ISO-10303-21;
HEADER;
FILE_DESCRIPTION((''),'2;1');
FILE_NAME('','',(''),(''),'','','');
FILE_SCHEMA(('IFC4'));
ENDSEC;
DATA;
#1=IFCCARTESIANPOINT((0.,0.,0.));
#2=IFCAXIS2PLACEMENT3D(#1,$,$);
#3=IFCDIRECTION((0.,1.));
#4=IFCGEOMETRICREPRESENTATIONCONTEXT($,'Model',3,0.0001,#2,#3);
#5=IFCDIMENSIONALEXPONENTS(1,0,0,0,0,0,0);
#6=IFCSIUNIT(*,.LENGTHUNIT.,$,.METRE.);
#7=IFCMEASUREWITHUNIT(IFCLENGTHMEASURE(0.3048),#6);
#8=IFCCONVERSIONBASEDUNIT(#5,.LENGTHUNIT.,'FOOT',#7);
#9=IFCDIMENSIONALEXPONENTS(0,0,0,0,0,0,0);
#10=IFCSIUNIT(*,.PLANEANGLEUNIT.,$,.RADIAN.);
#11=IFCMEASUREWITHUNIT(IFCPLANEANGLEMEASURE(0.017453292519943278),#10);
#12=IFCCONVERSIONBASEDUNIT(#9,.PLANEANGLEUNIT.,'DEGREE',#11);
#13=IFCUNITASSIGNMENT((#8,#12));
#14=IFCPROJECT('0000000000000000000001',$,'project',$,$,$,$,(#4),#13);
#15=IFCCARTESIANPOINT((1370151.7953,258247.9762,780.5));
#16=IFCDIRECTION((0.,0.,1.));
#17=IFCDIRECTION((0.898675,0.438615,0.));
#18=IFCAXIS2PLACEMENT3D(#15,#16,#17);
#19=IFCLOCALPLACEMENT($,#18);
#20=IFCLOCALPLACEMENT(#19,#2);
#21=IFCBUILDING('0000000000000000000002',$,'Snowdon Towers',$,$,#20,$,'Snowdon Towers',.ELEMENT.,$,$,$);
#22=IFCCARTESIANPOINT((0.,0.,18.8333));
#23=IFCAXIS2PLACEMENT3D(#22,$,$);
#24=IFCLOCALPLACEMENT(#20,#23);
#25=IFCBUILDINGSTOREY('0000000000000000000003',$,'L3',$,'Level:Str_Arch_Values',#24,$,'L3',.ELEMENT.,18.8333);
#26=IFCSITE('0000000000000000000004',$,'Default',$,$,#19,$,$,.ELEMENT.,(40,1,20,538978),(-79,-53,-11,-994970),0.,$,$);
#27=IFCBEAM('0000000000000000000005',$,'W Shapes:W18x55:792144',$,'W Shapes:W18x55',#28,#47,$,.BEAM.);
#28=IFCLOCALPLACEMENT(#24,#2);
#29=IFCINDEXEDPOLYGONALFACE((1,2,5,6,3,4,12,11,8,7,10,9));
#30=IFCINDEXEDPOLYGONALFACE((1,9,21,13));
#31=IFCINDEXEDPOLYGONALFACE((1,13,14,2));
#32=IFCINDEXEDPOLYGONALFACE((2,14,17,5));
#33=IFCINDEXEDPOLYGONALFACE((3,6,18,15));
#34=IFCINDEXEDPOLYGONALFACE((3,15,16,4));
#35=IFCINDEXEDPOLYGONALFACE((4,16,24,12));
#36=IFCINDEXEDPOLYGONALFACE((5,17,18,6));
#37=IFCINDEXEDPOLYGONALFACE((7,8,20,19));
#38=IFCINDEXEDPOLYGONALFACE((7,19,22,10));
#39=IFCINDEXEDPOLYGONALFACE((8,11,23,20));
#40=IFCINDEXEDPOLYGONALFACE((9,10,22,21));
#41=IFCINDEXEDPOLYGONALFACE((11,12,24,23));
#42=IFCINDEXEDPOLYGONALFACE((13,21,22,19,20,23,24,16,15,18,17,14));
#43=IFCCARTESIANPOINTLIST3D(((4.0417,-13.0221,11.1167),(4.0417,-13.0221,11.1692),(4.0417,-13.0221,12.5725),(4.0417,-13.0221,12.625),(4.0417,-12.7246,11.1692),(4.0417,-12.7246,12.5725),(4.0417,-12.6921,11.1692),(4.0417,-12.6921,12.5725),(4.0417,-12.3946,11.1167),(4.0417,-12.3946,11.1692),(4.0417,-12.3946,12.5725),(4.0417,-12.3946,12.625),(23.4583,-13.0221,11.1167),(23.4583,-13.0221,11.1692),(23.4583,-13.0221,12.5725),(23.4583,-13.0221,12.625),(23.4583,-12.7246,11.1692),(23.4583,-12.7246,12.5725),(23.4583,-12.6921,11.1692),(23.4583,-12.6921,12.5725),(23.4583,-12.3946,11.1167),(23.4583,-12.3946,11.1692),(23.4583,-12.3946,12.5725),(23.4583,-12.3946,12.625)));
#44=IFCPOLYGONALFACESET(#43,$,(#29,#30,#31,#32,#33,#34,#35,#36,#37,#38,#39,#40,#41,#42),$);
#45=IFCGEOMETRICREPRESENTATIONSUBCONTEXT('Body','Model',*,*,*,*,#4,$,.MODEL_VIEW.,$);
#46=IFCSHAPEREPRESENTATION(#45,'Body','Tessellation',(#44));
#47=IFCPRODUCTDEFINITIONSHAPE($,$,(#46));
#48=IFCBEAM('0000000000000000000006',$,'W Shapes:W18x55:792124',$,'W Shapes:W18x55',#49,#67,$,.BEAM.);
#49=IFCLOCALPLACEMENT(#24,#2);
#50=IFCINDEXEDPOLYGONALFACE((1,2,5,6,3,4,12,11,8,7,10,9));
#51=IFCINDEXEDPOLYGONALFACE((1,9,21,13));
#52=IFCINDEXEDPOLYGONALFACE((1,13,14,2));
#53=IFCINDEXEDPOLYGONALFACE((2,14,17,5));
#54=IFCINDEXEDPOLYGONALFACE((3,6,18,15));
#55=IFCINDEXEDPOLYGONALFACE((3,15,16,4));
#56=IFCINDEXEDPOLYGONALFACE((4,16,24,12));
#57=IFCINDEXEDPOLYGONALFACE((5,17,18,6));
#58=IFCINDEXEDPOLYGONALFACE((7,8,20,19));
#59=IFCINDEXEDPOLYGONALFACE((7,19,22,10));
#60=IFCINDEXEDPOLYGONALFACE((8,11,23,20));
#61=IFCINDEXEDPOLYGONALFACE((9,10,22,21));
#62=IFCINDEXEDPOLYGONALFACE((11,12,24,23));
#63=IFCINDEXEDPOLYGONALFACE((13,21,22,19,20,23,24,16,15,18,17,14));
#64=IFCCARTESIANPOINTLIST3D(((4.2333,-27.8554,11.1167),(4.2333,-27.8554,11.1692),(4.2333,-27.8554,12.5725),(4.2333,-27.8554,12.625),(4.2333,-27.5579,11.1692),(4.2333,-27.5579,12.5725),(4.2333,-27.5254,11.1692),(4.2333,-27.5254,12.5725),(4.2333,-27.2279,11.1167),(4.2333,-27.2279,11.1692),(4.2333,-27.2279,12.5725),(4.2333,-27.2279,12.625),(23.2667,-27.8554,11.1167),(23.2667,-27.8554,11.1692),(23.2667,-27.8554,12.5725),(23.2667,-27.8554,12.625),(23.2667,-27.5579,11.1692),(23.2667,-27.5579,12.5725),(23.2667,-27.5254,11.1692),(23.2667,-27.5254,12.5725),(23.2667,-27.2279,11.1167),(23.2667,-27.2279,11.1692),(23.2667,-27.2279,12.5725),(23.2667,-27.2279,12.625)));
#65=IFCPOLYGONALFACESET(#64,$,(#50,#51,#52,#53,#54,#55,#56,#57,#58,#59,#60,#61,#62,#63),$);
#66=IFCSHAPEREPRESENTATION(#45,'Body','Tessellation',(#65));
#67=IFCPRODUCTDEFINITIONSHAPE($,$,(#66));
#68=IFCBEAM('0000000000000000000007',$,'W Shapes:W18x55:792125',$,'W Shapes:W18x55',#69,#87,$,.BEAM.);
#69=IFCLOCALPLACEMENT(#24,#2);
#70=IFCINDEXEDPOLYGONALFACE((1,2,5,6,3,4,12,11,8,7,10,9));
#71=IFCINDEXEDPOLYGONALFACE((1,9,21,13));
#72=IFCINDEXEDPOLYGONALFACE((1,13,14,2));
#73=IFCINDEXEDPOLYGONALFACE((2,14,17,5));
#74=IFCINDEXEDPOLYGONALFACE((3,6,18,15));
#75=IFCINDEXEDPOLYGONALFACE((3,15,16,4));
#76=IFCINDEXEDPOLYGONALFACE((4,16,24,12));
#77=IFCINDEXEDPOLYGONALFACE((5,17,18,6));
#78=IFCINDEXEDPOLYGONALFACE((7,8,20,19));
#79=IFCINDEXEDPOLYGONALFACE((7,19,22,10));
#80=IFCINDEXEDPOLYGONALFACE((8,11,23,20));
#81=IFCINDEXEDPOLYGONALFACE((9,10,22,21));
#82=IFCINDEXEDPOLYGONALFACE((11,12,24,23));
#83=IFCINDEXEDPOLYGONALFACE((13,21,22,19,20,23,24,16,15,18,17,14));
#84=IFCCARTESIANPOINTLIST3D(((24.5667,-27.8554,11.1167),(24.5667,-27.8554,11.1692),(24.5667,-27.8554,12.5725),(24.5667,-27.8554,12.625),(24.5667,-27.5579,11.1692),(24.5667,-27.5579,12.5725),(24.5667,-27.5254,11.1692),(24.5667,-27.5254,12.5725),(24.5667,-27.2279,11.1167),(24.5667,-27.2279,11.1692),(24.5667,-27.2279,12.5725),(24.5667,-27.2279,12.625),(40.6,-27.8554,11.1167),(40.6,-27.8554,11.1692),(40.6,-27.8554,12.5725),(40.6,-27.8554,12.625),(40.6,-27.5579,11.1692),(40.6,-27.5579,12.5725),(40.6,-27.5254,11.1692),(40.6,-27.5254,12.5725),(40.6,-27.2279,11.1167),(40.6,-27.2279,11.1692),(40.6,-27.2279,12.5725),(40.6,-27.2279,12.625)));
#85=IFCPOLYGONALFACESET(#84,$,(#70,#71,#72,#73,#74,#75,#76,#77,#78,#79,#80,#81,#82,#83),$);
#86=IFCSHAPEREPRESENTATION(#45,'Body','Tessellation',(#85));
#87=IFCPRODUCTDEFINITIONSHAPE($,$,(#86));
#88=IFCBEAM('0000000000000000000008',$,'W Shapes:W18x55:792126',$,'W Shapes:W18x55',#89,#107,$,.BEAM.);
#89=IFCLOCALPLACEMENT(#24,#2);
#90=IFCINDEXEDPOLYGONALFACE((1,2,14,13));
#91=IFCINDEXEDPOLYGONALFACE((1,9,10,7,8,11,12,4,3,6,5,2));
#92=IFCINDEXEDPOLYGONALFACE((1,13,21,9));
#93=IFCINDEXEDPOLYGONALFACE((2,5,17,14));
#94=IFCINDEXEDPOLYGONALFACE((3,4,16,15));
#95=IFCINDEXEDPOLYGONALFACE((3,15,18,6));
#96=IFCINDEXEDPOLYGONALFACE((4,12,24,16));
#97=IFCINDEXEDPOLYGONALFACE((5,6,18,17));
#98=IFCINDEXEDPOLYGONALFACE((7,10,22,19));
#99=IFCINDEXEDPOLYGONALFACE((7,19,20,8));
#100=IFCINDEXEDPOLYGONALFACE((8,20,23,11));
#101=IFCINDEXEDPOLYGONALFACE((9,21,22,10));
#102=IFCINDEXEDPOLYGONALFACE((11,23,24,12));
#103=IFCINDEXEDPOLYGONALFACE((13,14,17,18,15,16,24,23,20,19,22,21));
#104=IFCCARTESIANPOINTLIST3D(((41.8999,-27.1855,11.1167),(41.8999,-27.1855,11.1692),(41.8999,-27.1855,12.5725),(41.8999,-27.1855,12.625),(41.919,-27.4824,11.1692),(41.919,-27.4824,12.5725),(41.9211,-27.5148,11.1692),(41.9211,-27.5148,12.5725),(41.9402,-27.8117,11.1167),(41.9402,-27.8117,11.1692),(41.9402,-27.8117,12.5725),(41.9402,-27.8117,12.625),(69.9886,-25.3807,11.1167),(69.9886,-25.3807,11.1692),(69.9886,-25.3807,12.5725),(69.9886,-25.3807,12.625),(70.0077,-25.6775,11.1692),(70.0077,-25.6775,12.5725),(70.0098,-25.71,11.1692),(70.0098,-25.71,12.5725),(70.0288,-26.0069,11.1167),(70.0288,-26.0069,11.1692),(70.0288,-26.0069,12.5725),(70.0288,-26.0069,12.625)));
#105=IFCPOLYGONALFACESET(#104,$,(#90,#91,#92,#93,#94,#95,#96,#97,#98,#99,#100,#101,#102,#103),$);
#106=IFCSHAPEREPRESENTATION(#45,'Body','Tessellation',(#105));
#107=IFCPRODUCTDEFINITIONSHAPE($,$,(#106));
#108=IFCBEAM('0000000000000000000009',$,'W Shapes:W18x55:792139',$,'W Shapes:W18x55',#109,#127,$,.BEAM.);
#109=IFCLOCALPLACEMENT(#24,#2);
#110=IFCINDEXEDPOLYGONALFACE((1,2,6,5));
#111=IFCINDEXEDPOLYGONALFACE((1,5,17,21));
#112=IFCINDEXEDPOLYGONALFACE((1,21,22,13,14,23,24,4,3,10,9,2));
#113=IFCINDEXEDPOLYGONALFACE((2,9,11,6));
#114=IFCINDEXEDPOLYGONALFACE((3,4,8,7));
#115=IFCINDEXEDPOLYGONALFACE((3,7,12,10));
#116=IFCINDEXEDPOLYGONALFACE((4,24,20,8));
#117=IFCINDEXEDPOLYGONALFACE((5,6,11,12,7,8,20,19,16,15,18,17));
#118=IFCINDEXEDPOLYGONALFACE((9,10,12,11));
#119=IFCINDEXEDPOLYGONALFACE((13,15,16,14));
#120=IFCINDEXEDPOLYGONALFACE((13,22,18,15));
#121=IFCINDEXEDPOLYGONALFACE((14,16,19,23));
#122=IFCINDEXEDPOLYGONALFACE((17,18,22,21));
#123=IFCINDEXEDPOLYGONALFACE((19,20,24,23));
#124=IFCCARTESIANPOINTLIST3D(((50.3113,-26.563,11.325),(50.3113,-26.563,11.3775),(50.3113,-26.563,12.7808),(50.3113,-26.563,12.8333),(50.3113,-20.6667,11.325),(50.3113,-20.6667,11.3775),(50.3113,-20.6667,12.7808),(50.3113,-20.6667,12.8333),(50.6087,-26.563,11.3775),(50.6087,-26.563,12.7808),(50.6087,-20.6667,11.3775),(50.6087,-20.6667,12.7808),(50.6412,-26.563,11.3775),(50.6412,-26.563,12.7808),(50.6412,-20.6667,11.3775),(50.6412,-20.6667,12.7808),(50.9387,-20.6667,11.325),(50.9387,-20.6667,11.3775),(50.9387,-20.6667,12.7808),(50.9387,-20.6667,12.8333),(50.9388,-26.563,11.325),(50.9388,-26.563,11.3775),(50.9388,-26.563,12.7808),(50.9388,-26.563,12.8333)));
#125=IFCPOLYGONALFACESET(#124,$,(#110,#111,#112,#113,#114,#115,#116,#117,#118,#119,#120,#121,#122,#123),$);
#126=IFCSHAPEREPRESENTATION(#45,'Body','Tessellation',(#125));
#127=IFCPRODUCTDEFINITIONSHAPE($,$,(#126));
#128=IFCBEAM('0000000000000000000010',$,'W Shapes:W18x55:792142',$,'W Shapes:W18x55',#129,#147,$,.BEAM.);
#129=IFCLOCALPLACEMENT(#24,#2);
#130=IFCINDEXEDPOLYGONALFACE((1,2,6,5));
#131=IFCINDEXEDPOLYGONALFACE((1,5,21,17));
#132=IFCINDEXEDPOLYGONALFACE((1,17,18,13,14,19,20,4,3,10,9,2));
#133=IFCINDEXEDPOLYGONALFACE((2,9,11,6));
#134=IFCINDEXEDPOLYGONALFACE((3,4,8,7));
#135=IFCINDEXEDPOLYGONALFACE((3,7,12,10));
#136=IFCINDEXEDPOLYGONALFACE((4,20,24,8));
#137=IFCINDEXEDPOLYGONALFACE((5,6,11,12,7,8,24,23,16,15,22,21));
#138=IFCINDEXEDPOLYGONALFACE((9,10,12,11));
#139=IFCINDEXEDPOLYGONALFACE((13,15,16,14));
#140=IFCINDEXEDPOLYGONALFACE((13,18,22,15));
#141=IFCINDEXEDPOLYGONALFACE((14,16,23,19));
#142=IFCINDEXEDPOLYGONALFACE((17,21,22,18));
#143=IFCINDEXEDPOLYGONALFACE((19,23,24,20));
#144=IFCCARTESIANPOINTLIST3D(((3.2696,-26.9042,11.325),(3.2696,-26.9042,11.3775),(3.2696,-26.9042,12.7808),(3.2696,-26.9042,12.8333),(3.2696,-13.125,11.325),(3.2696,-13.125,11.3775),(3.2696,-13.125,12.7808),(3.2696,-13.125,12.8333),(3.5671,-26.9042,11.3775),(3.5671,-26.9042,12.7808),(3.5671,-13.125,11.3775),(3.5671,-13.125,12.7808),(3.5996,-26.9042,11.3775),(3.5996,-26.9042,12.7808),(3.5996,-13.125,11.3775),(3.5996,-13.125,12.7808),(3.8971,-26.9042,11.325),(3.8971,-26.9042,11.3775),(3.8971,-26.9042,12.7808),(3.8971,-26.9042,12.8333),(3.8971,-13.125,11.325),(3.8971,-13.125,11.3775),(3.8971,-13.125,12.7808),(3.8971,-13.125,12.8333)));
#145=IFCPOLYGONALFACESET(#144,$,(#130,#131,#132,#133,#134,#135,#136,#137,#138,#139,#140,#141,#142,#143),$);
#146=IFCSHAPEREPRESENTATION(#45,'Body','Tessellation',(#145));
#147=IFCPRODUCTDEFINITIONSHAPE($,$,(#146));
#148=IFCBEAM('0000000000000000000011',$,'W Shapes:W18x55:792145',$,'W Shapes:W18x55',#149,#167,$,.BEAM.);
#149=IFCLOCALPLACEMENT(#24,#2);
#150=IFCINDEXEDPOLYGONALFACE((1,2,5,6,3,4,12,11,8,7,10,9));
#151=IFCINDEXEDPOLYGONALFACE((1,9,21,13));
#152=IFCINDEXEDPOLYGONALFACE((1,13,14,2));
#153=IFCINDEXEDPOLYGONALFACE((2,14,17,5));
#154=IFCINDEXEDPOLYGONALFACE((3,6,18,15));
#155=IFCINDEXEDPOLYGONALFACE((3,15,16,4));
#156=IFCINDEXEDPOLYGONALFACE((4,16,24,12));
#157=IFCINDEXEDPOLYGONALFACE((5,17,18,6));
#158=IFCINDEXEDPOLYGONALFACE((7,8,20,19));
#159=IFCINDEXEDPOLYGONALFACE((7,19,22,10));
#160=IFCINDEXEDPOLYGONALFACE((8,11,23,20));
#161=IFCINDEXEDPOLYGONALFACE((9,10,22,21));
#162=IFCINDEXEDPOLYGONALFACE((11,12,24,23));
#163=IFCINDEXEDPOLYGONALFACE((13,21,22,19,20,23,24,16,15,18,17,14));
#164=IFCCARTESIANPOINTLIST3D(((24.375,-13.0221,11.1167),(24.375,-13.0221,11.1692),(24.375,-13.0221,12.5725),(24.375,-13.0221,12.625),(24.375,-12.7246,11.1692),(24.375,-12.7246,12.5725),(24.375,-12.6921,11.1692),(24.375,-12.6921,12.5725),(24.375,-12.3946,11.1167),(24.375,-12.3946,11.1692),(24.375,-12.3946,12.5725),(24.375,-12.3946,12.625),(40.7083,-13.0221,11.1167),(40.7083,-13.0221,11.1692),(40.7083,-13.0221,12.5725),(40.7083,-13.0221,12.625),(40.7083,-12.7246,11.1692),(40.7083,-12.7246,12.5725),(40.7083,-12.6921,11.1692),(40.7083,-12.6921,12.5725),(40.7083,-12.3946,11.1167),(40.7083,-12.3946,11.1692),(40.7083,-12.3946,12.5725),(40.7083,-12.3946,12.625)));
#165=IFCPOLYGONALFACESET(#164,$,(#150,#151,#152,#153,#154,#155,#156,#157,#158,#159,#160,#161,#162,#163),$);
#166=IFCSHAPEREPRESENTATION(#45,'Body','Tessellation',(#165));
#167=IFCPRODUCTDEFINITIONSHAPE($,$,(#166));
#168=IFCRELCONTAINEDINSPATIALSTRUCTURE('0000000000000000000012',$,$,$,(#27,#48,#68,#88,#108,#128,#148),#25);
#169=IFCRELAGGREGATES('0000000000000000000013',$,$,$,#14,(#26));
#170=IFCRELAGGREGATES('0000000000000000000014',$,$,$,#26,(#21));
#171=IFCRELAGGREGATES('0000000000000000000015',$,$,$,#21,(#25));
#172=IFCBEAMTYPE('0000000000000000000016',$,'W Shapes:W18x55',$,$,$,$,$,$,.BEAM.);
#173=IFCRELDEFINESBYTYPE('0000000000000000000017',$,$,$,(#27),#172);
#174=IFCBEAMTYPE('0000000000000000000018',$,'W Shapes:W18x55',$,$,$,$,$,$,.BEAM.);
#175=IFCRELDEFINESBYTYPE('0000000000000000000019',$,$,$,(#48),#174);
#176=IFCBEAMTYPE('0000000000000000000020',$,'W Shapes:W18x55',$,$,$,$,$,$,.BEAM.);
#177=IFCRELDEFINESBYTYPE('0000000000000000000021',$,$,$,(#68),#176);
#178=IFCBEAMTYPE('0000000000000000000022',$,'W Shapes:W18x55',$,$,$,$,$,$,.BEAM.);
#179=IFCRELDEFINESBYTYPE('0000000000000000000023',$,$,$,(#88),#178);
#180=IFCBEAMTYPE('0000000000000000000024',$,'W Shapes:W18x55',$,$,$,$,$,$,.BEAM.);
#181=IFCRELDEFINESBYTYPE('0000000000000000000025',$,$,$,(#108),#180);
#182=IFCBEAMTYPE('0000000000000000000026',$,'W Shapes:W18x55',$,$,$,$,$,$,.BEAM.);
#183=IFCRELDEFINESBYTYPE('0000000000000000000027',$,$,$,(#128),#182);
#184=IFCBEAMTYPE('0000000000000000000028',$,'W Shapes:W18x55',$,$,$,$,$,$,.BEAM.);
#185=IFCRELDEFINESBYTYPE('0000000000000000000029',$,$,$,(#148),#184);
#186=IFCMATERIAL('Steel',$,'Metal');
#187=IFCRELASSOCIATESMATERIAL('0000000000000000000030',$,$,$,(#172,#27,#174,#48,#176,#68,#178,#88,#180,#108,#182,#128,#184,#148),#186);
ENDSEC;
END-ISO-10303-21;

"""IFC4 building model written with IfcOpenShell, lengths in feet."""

from ifc_helpers import new_model, entity, si_unit, converted_unit, direction, frame, origin, place, context, subcontext, project, spatial, indexed_curve, outline, extrude, source, transform, mapped, material, type_object, type_shapes, element, save


model = new_model("IFC4")

# Units and contexts
model_context = context("Model", 3, precision=0.0001, world=origin(), true_north=direction((0.0, 1.0)))
body_context = subcontext(model_context, "Body", "Model", "MODEL_VIEW")
ifc_project = project(units=[converted_unit("LENGTHUNIT", "FOOT", entity("IfcLengthMeasure", 0.3048), si_unit("LENGTHUNIT", "METRE"), dimensions=[1, 0, 0, 0, 0, 0, 0]), converted_unit("PLANEANGLEUNIT", "DEGREE", entity("IfcPlaneAngleMeasure", 0.017453292519943278), si_unit("PLANEANGLEUNIT", "RADIAN"), dimensions=[0, 0, 0, 0, 0, 0, 0])], contexts=[model_context])

# Site, building, storey
site_placement = place(None, frame((1370151.7953, 258247.9762, 780.5), z_axis=(0.0, 0.0, 1.0), x_axis=(0.898675, 0.438615, 0.0)))
site = spatial("IfcSite", under=ifc_project, at=site_placement, Name="Default", CompositionType="ELEMENT", RefLatitude=(40, 1, 20, 538978), RefLongitude=(-79, -53, -11, -994970), RefElevation=0.0)
building_placement = place(site_placement, origin())
building = spatial("IfcBuilding", under=site, at=building_placement, Name="Snowdon Towers", LongName="Snowdon Towers", CompositionType="ELEMENT")
storey_placement = place(building_placement, frame((0.0, 0.0, 18.8333)))
storey = spatial("IfcBuildingStorey", under=building, at=storey_placement, Name="L3", ObjectType="Level:Str_Arch_Values", LongName="L3", CompositionType="ELEMENT", Elevation=18.8333)

# Beams
ifc_material = material(Name="Steel", Category="Metal")
beam_type_1 = type_object("IfcBeamType", Name="W Shapes:W18x55", PredefinedType="BEAM", material=ifc_material)
shared_shape_1 = source(origin(), body_context, "Body", "SweptSolid", [
    extrude(outline(indexed_curve([(-0.3138, -0.7017), (-0.3138, -0.7542), (0.3138, -0.7542), (0.3138, -0.7017), (0.0162, -0.7017), (0.0162, 0.7017), (0.3138, 0.7017), (0.3138, 0.7542), (-0.3137, 0.7542), (-0.3137, 0.7017), (-0.0163, 0.7017), (-0.0163, -0.7017), (-0.3138, -0.7017)], self_intersect=False)), frame((-9.7917, 0.0, 0.0), z_axis=(-1.0, 0.0, 0.0), x_axis=(0.0, -1.0, 0.0)), (0.0, 0.0, -1.0), 19.4167),
])
type_shapes(beam_type_1, [shared_shape_1])
beam_1_placement = place(storey_placement, frame((13.8333, -12.7083, 11.8708)))
element("IfcBeam", 1, at=beam_1_placement, inside=storey, type_object=beam_type_1, material=ifc_material, Name="W Shapes:W18x55:792144", ObjectType="W Shapes:W18x55", PredefinedType="BEAM", context=body_context, shape_type="MappedRepresentation", body=[
    mapped(shared_shape_1, transform((0.0, 0.0, 0.0), scale=1.0)),
])
beam_type_2 = type_object("IfcBeamType", Name="W Shapes:W18x55", PredefinedType="BEAM", material=ifc_material)
shared_shape_2 = source(origin(), body_context, "Body", "SweptSolid", [
    extrude(outline(indexed_curve([(-0.3138, -0.7017), (-0.3138, -0.7542), (0.3138, -0.7542), (0.3138, -0.7017), (0.0162, -0.7017), (0.0162, 0.7017), (0.3138, 0.7017), (0.3138, 0.7542), (-0.3137, 0.7542), (-0.3137, 0.7017), (-0.0163, 0.7017), (-0.0163, -0.7017), (-0.3138, -0.7017)], self_intersect=False)), frame((-9.6, 0.0, 0.0), z_axis=(-1.0, 0.0, 0.0), x_axis=(0.0, -1.0, 0.0)), (0.0, 0.0, -1.0), 19.0333),
])
type_shapes(beam_type_2, [shared_shape_2])
beam_2_placement = place(storey_placement, frame((13.8333, -27.5417, 11.8708)))
element("IfcBeam", 2, at=beam_2_placement, inside=storey, type_object=beam_type_2, material=ifc_material, Name="W Shapes:W18x55:792124", ObjectType="W Shapes:W18x55", PredefinedType="BEAM", context=body_context, shape_type="MappedRepresentation", body=[
    mapped(shared_shape_2, transform((0.0, 0.0, 0.0), scale=1.0)),
])
beam_type_3 = type_object("IfcBeamType", Name="W Shapes:W18x55", PredefinedType="BEAM", material=ifc_material)
shared_shape_3 = source(origin(), body_context, "Body", "SweptSolid", [
    extrude(outline(indexed_curve([(-0.3138, -0.7017), (-0.3138, -0.7542), (0.3138, -0.7542), (0.3138, -0.7017), (0.0162, -0.7017), (0.0162, 0.7017), (0.3138, 0.7017), (0.3138, 0.7542), (-0.3137, 0.7542), (-0.3137, 0.7017), (-0.0163, 0.7017), (-0.0163, -0.7017), (-0.3138, -0.7017)], self_intersect=False)), frame((-8.0167, 0.0, 0.0), z_axis=(-1.0, 0.0, 0.0), x_axis=(0.0, -1.0, 0.0)), (0.0, 0.0, -1.0), 16.0333),
])
type_shapes(beam_type_3, [shared_shape_3])
beam_3_placement = place(storey_placement, frame((32.5833, -27.5417, 11.8708)))
element("IfcBeam", 3, at=beam_3_placement, inside=storey, type_object=beam_type_3, material=ifc_material, Name="W Shapes:W18x55:792125", ObjectType="W Shapes:W18x55", PredefinedType="BEAM", context=body_context, shape_type="MappedRepresentation", body=[
    mapped(shared_shape_3, transform((0.0, 0.0, 0.0), scale=1.0)),
])
beam_type_4 = type_object("IfcBeamType", Name="W Shapes:W18x55", PredefinedType="BEAM", material=ifc_material)
shared_shape_4 = source(origin(), body_context, "Body", "SweptSolid", [
    extrude(outline(indexed_curve([(-0.3138, -0.7017), (-0.3138, -0.7542), (0.3138, -0.7542), (0.3138, -0.7017), (0.0162, -0.7017), (0.0162, 0.7017), (0.3138, 0.7017), (0.3138, 0.7542), (-0.3137, 0.7542), (-0.3137, 0.7017), (-0.0163, 0.7017), (-0.0163, -0.7017), (-0.3138, -0.7017)], self_intersect=False)), frame((-14.3614, 0.0, 0.0), z_axis=(-1.0, 0.0, 0.0), x_axis=(0.0, -1.0, 0.0)), (0.0, 0.0, -1.0), 28.1466),
])
type_shapes(beam_type_4, [shared_shape_4])
beam_4_placement = place(storey_placement, frame((56.2518, -26.5777, 11.8708), z_axis=(0.0, 0.0, 1.0), x_axis=(0.997942, 0.064123, 0.0)))
element("IfcBeam", 4, at=beam_4_placement, inside=storey, type_object=beam_type_4, material=ifc_material, Name="W Shapes:W18x55:792126", ObjectType="W Shapes:W18x55", PredefinedType="BEAM", context=body_context, shape_type="MappedRepresentation", body=[
    mapped(shared_shape_4, transform((0.0, 0.0, 0.0), scale=1.0)),
])
beam_type_5 = type_object("IfcBeamType", Name="W Shapes:W18x55", PredefinedType="BEAM", material=ifc_material)
shared_shape_5 = source(origin(), body_context, "Body", "SweptSolid", [
    extrude(outline(indexed_curve([(-0.3138, -0.7017), (-0.3138, -0.7542), (0.3138, -0.7542), (0.3138, -0.7017), (0.0162, -0.7017), (0.0162, 0.7017), (0.3138, 0.7017), (0.3138, 0.7542), (-0.3137, 0.7542), (-0.3137, 0.7017), (-0.0163, 0.7017), (-0.0163, -0.7017), (-0.3138, -0.7017)], self_intersect=False)), frame((-2.8655, 0.0, 0.0), z_axis=(-1.0, 0.0, 0.0), x_axis=(0.0, -1.0, 0.0)), (0.0, 0.0, -1.0), 5.8964),
])
type_shapes(beam_type_5, [shared_shape_5])
beam_5_placement = place(storey_placement, frame((50.625, -23.5321, 12.0792), z_axis=(0.0, 0.0, 1.0), x_axis=(0.0, -1.0, 0.0)))
element("IfcBeam", 5, at=beam_5_placement, inside=storey, type_object=beam_type_5, material=ifc_material, Name="W Shapes:W18x55:792139", ObjectType="W Shapes:W18x55", PredefinedType="BEAM", context=body_context, shape_type="MappedRepresentation", body=[
    mapped(shared_shape_5, transform((0.0, 0.0, 0.0), scale=1.0)),
])
beam_type_6 = type_object("IfcBeamType", Name="W Shapes:W18x55", PredefinedType="BEAM", material=ifc_material)
shared_shape_6 = source(origin(), body_context, "Body", "SweptSolid", [
    extrude(outline(indexed_curve([(-0.3138, -0.7017), (-0.3138, -0.7542), (0.3138, -0.7542), (0.3138, -0.7017), (0.0162, -0.7017), (0.0162, 0.7017), (0.3138, 0.7017), (0.3138, 0.7542), (-0.3137, 0.7542), (-0.3137, 0.7017), (-0.0163, 0.7017), (-0.0163, -0.7017), (-0.3138, -0.7017)], self_intersect=False)), frame((-7.2292, 0.0, 0.0), z_axis=(-1.0, 0.0, 0.0), x_axis=(0.0, -1.0, 0.0)), (0.0, 0.0, -1.0), 13.7792),
])
type_shapes(beam_type_6, [shared_shape_6])
beam_6_placement = place(storey_placement, frame((3.5833, -20.3542, 12.0792), z_axis=(0.0, 0.0, 1.0), x_axis=(0.0, -1.0, 0.0)))
element("IfcBeam", 6, at=beam_6_placement, inside=storey, type_object=beam_type_6, material=ifc_material, Name="W Shapes:W18x55:792142", ObjectType="W Shapes:W18x55", PredefinedType="BEAM", context=body_context, shape_type="MappedRepresentation", body=[
    mapped(shared_shape_6, transform((0.0, 0.0, 0.0), scale=1.0)),
])
beam_type_7 = type_object("IfcBeamType", Name="W Shapes:W18x55", PredefinedType="BEAM", material=ifc_material)
shared_shape_7 = source(origin(), body_context, "Body", "SweptSolid", [
    extrude(outline(indexed_curve([(-0.3138, -0.7017), (-0.3138, -0.7542), (0.3138, -0.7542), (0.3138, -0.7017), (0.0162, -0.7017), (0.0162, 0.7017), (0.3138, 0.7017), (0.3138, 0.7542), (-0.3137, 0.7542), (-0.3137, 0.7017), (-0.0163, 0.7017), (-0.0163, -0.7017), (-0.3138, -0.7017)], self_intersect=False)), frame((-8.2083, 0.0, 0.0), z_axis=(-1.0, 0.0, 0.0), x_axis=(0.0, -1.0, 0.0)), (0.0, 0.0, -1.0), 16.3333),
])
type_shapes(beam_type_7, [shared_shape_7])
beam_7_placement = place(storey_placement, frame((32.5833, -12.7083, 11.8708)))
element("IfcBeam", 7, at=beam_7_placement, inside=storey, type_object=beam_type_7, material=ifc_material, Name="W Shapes:W18x55:792145", ObjectType="W Shapes:W18x55", PredefinedType="BEAM", context=body_context, shape_type="MappedRepresentation", body=[
    mapped(shared_shape_7, transform((0.0, 0.0, 0.0), scale=1.0)),
])

save(model, "model.ifc")
